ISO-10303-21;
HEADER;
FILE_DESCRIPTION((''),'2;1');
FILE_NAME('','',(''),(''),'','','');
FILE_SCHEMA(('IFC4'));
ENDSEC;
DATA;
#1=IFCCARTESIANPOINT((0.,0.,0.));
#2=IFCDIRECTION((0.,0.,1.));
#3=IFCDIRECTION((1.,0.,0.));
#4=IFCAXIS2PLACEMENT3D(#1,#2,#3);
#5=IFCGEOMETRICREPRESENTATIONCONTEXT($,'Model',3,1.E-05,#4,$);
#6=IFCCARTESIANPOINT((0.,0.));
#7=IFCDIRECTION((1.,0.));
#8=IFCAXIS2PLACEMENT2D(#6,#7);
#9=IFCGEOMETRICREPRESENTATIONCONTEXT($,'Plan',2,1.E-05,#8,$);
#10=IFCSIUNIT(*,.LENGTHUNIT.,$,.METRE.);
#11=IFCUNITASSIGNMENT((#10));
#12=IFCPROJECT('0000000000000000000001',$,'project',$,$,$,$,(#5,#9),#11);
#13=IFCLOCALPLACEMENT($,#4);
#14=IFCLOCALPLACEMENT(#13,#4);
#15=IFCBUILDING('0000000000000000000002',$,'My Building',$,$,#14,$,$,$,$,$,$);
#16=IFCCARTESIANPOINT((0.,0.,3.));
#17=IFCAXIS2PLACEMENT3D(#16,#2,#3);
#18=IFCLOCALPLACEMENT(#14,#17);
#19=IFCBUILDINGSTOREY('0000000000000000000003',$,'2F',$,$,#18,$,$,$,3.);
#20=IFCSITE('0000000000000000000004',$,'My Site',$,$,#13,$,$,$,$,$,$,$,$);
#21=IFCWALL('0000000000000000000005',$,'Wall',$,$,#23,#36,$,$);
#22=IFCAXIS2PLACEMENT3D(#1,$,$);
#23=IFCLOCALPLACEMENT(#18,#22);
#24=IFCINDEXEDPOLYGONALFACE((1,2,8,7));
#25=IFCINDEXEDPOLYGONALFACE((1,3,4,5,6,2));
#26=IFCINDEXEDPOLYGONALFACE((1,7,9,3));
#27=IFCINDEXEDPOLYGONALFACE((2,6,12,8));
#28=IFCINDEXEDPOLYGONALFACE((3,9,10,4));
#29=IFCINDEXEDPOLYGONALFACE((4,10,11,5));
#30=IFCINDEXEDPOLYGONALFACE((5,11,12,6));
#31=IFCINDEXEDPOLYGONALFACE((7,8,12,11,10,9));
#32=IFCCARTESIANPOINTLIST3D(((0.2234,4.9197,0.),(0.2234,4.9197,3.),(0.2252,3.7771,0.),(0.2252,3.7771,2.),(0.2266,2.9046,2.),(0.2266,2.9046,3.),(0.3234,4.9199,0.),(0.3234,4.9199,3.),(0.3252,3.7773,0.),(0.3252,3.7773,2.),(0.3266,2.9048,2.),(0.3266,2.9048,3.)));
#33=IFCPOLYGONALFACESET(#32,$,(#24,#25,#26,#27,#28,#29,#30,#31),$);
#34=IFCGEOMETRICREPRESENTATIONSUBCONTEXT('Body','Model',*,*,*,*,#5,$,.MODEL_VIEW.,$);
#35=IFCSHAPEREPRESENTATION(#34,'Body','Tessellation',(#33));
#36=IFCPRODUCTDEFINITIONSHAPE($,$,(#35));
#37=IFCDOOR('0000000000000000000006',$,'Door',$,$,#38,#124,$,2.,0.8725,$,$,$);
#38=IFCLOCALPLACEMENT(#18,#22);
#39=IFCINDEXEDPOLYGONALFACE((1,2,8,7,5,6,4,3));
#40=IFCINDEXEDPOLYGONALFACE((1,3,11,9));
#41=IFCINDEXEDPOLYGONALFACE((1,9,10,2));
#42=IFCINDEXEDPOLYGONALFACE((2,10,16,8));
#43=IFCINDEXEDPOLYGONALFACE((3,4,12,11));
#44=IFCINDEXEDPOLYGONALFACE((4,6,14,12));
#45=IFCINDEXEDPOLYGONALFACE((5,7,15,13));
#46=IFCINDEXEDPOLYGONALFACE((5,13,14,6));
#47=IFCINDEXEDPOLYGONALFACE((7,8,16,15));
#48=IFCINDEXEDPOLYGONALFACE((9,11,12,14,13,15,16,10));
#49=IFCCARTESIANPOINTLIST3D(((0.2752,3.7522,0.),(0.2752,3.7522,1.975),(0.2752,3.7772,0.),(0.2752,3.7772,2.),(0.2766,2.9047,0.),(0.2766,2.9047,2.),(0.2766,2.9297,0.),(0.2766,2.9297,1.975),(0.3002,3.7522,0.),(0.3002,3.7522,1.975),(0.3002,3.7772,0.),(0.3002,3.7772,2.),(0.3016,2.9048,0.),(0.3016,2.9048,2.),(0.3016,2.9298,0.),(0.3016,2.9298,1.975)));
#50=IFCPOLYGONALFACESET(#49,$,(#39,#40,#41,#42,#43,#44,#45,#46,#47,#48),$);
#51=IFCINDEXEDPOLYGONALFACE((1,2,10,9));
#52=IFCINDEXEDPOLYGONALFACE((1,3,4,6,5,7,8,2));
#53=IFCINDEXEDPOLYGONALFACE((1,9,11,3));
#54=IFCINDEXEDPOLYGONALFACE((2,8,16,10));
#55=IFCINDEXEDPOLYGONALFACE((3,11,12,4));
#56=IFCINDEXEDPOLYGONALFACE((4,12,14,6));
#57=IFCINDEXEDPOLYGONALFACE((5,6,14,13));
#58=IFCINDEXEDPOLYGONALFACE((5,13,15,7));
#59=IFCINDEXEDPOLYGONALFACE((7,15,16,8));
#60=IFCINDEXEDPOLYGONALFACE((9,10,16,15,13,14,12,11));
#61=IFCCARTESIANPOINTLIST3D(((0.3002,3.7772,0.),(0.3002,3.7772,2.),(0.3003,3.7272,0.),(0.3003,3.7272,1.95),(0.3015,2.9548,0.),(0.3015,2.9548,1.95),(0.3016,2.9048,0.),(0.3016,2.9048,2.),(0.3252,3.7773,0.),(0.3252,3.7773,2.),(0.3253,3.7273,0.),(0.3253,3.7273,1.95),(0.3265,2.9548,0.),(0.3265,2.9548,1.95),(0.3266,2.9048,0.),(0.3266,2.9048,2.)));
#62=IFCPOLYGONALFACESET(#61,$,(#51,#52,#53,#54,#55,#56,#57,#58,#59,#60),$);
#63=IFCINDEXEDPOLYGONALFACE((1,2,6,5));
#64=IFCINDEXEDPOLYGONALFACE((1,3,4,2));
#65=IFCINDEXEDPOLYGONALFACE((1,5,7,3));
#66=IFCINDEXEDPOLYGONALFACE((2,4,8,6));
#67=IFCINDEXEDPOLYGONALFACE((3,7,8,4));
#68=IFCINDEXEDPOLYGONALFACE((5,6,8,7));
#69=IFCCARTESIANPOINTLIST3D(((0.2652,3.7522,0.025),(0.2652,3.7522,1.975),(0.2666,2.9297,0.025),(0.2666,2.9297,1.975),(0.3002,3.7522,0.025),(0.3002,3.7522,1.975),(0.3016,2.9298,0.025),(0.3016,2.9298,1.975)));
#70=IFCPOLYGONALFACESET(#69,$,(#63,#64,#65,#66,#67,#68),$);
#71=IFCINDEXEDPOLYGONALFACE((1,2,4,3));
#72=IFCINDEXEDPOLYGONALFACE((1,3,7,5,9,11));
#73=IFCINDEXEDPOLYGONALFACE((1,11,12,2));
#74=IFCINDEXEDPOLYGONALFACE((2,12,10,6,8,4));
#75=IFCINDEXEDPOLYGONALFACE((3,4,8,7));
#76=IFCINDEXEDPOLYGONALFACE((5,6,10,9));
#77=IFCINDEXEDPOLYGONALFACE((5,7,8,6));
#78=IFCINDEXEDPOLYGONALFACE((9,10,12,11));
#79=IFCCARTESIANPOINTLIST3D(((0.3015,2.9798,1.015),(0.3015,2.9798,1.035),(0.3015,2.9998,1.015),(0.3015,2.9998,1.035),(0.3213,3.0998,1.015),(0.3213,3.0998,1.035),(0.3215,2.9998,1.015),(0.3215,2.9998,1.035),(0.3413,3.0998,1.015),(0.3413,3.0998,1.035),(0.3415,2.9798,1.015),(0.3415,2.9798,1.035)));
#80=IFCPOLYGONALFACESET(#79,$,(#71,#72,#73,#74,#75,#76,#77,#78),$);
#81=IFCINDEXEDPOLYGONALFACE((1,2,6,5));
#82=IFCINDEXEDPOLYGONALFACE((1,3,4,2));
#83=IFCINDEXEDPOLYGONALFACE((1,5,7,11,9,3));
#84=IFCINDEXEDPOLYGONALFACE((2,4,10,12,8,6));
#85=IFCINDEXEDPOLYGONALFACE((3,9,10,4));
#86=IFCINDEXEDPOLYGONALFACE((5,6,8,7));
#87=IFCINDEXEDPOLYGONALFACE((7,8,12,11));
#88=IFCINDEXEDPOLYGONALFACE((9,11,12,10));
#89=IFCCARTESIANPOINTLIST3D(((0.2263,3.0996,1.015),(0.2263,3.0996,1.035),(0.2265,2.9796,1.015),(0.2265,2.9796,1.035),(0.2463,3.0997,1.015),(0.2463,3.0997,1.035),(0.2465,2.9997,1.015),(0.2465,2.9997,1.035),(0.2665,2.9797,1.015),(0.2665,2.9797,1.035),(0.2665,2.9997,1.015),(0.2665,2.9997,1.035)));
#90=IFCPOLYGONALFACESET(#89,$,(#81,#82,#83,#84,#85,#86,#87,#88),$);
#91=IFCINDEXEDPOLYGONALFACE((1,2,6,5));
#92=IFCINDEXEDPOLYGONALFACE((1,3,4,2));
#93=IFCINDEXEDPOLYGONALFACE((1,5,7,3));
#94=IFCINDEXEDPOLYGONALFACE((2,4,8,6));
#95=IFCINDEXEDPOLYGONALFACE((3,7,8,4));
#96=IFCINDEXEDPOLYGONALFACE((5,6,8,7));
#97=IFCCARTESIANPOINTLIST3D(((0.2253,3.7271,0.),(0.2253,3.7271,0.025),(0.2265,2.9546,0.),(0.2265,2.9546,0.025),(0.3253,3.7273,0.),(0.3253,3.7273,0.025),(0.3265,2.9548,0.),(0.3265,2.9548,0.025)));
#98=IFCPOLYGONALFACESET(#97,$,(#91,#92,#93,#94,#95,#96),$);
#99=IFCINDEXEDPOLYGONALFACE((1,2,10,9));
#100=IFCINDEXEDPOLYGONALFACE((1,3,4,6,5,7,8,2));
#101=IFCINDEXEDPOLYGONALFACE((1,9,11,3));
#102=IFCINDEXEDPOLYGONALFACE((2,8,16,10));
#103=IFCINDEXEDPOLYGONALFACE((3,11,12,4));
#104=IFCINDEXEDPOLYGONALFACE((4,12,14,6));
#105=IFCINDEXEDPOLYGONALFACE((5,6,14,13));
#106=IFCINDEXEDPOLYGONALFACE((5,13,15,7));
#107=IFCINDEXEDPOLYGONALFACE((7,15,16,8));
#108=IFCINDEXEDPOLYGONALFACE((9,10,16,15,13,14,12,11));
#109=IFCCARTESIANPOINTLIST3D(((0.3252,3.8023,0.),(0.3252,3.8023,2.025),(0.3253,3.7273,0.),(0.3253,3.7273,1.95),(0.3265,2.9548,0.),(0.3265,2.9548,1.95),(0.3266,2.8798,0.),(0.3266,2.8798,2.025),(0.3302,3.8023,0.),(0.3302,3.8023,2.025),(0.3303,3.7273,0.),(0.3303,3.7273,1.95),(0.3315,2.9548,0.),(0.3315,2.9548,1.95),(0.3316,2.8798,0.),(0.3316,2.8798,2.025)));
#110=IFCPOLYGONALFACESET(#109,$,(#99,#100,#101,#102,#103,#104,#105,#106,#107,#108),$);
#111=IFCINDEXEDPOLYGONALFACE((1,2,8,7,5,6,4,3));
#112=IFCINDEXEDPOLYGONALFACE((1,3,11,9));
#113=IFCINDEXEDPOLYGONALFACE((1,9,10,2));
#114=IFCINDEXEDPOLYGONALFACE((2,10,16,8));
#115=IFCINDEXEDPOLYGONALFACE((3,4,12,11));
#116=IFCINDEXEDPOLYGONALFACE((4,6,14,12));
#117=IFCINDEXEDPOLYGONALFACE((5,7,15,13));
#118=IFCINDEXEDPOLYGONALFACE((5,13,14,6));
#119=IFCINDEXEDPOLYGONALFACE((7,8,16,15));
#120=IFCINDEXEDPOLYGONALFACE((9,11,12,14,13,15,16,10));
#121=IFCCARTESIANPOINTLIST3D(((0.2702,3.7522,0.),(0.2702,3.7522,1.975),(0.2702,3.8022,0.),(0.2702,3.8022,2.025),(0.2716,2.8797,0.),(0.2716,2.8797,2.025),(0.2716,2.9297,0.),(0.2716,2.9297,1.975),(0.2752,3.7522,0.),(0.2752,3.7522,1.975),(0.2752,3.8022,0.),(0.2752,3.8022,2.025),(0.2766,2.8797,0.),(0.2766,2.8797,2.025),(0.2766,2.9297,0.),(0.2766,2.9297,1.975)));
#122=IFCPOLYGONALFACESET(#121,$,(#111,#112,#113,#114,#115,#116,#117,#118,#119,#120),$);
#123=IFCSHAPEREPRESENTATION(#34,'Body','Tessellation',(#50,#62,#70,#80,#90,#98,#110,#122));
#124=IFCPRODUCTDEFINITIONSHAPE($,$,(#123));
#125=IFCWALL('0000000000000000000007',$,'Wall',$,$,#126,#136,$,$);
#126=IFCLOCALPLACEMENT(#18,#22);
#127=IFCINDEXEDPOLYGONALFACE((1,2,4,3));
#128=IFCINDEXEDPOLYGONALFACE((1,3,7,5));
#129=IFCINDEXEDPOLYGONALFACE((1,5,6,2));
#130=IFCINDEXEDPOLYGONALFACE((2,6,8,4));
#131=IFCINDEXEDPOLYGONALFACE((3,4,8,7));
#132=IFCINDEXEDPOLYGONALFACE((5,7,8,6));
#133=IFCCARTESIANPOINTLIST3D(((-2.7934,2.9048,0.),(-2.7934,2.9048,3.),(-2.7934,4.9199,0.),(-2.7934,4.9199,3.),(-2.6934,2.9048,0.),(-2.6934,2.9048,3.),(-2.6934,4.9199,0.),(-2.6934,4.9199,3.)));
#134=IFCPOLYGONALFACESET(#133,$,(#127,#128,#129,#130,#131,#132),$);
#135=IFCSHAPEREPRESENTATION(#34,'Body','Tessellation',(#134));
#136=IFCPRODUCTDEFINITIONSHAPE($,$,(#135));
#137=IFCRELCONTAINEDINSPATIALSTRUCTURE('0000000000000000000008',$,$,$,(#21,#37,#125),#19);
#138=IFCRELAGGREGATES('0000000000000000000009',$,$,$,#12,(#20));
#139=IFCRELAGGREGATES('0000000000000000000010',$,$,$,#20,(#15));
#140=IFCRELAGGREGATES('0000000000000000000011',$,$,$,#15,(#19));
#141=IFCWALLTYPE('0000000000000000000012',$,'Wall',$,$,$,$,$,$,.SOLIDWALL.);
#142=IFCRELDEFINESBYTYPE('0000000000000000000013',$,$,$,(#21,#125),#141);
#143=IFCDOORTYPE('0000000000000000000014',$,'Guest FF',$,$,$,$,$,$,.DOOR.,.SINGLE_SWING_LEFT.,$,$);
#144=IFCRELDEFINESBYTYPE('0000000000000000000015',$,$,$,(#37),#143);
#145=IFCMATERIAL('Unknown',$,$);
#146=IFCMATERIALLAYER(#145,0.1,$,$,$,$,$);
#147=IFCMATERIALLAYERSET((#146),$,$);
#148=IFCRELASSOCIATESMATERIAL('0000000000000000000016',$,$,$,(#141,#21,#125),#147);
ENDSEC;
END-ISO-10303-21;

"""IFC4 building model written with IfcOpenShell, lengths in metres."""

from ifc_helpers import new_model, entity, si_unit, frame, origin_with_axes, origin_2d_with_axis, place, context, subcontext, project, spatial, line, indexed_curve, outline, extrude, shape, source, transform, mapped, material, layer, layer_set, layer_usage, type_object, type_shapes, element, fill, save


model = new_model("IFC4")

# Units and contexts
model_context = context("Model", 3, precision=1e-05, world=origin_with_axes())
plan_context = context("Plan", 2, precision=1e-05, world=origin_2d_with_axis())
body_context_1 = subcontext(model_context, "Body", "Model", "MODEL_VIEW")
body_context_2 = subcontext(plan_context, "Body", "Plan", "PLAN_VIEW")
ifc_project = project(units=[si_unit("LENGTHUNIT", "METRE")], contexts=[model_context, plan_context])

# Site, building, storey
site_placement = place(None, origin_with_axes())
site = spatial("IfcSite", under=ifc_project, at=site_placement, Name="My Site")
building_placement = place(site_placement, origin_with_axes())
building = spatial("IfcBuilding", under=site, at=building_placement, Name="My Building")
storey_placement = place(building_placement, frame((0.0, 0.0, 3.0), z_axis=(0.0, 0.0, 1.0), x_axis=(1.0, 0.0, 0.0)))
storey = spatial("IfcBuildingStorey", under=building, at=storey_placement, Name="2F", Elevation=3.0)

# Shared definitions
ifc_material = material(Name="Unknown")

# Shared definitions
ifc_layer_1 = layer(ifc_material, 0.1)
ifc_layer_set_1 = layer_set([ifc_layer_1])
wall_type = type_object("IfcWallType", Name="Wall", PredefinedType="SOLIDWALL", material=ifc_layer_set_1)

# Shared definitions
shared_shape_1 = source(origin_with_axes(), body_context_1, "Body", "SweptSolid", [
    extrude(outline(indexed_curve([(0.0, 0.0), (0.8725, 0.0), (0.8725, 2.0), (0.0, 2.0)], segments=[line(1, 2, 3, 4, 1)])), frame((0.0, -0.6, 0.0), z_axis=(0.0, -1.0, 0.0), x_axis=(1.0, 0.0, 0.0)), (0.0, 0.0, -1.0), 1.2),
])
door_type_1 = type_object("IfcDoorType", Name="Guest FF", OperationType="SINGLE_SWING_LEFT", PredefinedType="DOOR")
shared_shape_2 = source(origin_with_axes(), body_context_1, "Body", "SweptSolid", [
    extrude(outline(indexed_curve([(0.0, 0.0), (0.0, 2.0), (0.8725, 2.0), (0.8725, 0.0), (0.8475, 0.0), (0.8475, 1.975), (0.025, 1.975), (0.025, 0.0)], segments=[line(1, 2, 3, 4, 5, 6, 7, 8, 1)])), frame((0.0, 0.025, 0.0), z_axis=(0.0, -1.0, 0.0), x_axis=(1.0, 0.0, 0.0)), (0.0, 0.0, -1.0), 0.025),
    extrude(outline(indexed_curve([(0.0, 0.0), (0.0, 2.0), (0.8725, 2.0), (0.8725, 0.0), (0.8225, 0.0), (0.8225, 1.95), (0.05, 1.95), (0.05, 0.0)], segments=[line(1, 2, 3, 4, 5, 6, 7, 8, 1)])), frame((0.0, 0.0, 0.0), z_axis=(0.0, -1.0, 0.0), x_axis=(1.0, 0.0, 0.0)), (0.0, 0.0, -1.0), 0.025),
    extrude(outline(indexed_curve([(0.0, 0.0), (0.8225, 0.0), (0.8225, 0.035), (0.0, 0.035)], segments=[line(1, 2, 3, 4, 1)])), frame((0.025, 0.025, 0.025), z_axis=(0.0, 0.0, 1.0), x_axis=(1.0, 0.0, 0.0)), (0.0, 0.0, 1.0), 1.95),
    extrude(outline(indexed_curve([(0.0, 0.0), (0.0, -0.04), (0.12, -0.04), (0.12, -0.02), (0.02, -0.02), (0.02, 0.0)], segments=[line(1, 2, 3, 4, 5, 6, 1)])), frame((0.075, 0.025, 1.015), z_axis=(0.0, 0.0, 1.0), x_axis=(1.0, 0.0, 0.0)), (0.0, 0.0, 1.0), 0.02),
    extrude(outline(indexed_curve([(0.0, 0.0), (0.0, 0.04), (0.12, 0.04), (0.12, 0.02), (0.02, 0.02), (0.02, 0.0)], segments=[line(1, 2, 3, 4, 5, 6, 1)])), frame((0.075, 0.06, 1.015), z_axis=(0.0, 0.0, 1.0), x_axis=(1.0, 0.0, 0.0)), (0.0, 0.0, 1.0), 0.02),
    extrude(outline(indexed_curve([(0.0, 0.0), (0.7725, 0.0), (0.7725, 0.1), (0.0, 0.1)], segments=[line(1, 2, 3, 4, 1)])), frame((0.05, 0.0, 0.0), z_axis=(0.0, 0.0, 1.0), x_axis=(1.0, 0.0, 0.0)), (0.0, 0.0, 1.0), 0.025),
    extrude(outline(indexed_curve([(0.0, 0.0), (0.0, 2.025), (0.9225, 2.025), (0.9225, 0.0), (0.8475, 0.0), (0.8475, 1.95), (0.075, 1.95), (0.075, 0.0)], segments=[line(1, 2, 3, 4, 5, 6, 7, 8, 1)])), frame((-0.025, -0.005, 0.0), z_axis=(0.0, -1.0, 0.0), x_axis=(1.0, 0.0, 0.0)), (0.0, 0.0, -1.0), 0.005),
    extrude(outline(indexed_curve([(0.0, 0.0), (0.0, 2.025), (0.9225, 2.025), (0.9225, 0.0), (0.8725, 0.0), (0.8725, 1.975), (0.05, 1.975), (0.05, 0.0)], segments=[line(1, 2, 3, 4, 5, 6, 7, 8, 1)])), frame((-0.025, 0.05, 0.0), z_axis=(0.0, -1.0, 0.0), x_axis=(1.0, 0.0, 0.0)), (0.0, 0.0, -1.0), 0.005),
])
shared_shape_3 = source(origin_with_axes(), body_context_2, "Body", "Curve2D", [
    entity("IfcIndexedPolyCurve", entity("IfcCartesianPointList2D", [[0.0, 0.0], [0.0, 0.05], [0.025, 0.05], [0.025, 0.025], [0.05, 0.025], [0.05, 0.0]]), [entity("IfcLineIndex", [1, 2, 3, 4, 5, 6, 1])]),
    entity("IfcIndexedPolyCurve", entity("IfcCartesianPointList2D", [[0.8725, 0.0], [0.8725, 0.05], [0.8475, 0.05], [0.8475, 0.025], [0.8225, 0.025], [0.8225, 0.0]]), [entity("IfcLineIndex", [1, 2, 3, 4, 5, 6, 1])]),
    entity("IfcTrimmedCurve", entity("IfcEllipse", entity("IfcAxis2Placement2D", entity("IfcCartesianPoint", [0.8125, 0.05]), entity("IfcDirection", [1.0, 0.0])), 0.7875, 0.8225), [entity("IfcCartesianPoint", [0.8125, 0.8725])], [entity("IfcCartesianPoint", [0.025, 0.05])], True, "CARTESIAN"),
    entity("IfcIndexedPolyCurve", entity("IfcCartesianPointList2D", [[0.8475, 0.05], [0.8125, 0.05], [0.8125, 0.8725], [0.8475, 0.8725]]), [entity("IfcLineIndex", [1, 2, 3, 4, 1])]),
])
type_shapes(door_type_1, [shared_shape_2, shared_shape_3])

# Wall, opening, door
ifc_layer_usage_1 = layer_usage(ifc_layer_set_1, "AXIS2", "POSITIVE", 0.0)
wall_1_placement = place(storey_placement, frame((0.3266, 2.9048, 0.0), z_axis=(0.0, 0.0, 1.0), x_axis=(-0.001613, 0.999999, 0.0)))
wall_1 = element("IfcWall", 1, at=wall_1_placement, inside=storey, type_object=wall_type, material=ifc_layer_usage_1, Name="Wall", context=body_context_1, shape_type="SweptSolid", body=[
    extrude(outline(indexed_curve([(0.0, 0.0), (0.0, 0.1), (2.0151, 0.1), (2.0151, 0.0)], segments=[line(1, 2, 3, 4, 1)])), origin_with_axes(), (0.0, 0.0, 1.0), 3.0),
])
opening_1_placement = place(wall_1_placement, frame((0.0, 0.0, 0.0), z_axis=(0.0, 0.0, 1.0), x_axis=(1.0, 0.0, 0.0)))
opening_1 = element("IfcOpeningElement", 2, at=opening_1_placement, cuts=wall_1, PredefinedType="OPENING", context=body_context_1, shape_type="MappedRepresentation", body=[
    mapped(shared_shape_1, transform((0.0, 0.0, 0.0), x_axis=(1.0, 0.0, 0.0), y_axis=(0.0, 1.0, 0.0), z_axis=(0.0, 0.0, 1.0), scale=1.0)),
])
door_1_placement = place(opening_1_placement, frame((0.0, 0.0, 0.0), z_axis=(0.0, 0.0, 1.0), x_axis=(1.0, 0.0, 0.0)))
door_1 = element("IfcDoor", 3, at=door_1_placement, inside=storey, type_object=door_type_1, Name="Door", OverallHeight=2.0, OverallWidth=0.8725, shapes=[
    shape(body_context_1, "Body", "MappedRepresentation", [mapped(shared_shape_2, transform((0.0, 0.0, 0.0), x_axis=(1.0, 0.0, 0.0), y_axis=(0.0, 1.0, 0.0), z_axis=(0.0, 0.0, 1.0), scale=1.0))]),
    shape(body_context_2, "Body", "MappedRepresentation", [mapped(shared_shape_3, transform((0.0, 0.0, 0.0), x_axis=(1.0, 0.0, 0.0), y_axis=(0.0, 1.0, 0.0), z_axis=(0.0, 0.0, 1.0), scale=1.0))]),
])
fill(opening_1, door_1)

# Wall
ifc_layer_usage_2 = layer_usage(ifc_layer_set_1, "AXIS2", "POSITIVE", 0.0)
wall_2_placement = place(storey_placement, frame((-2.6934, 2.9048, 0.0), z_axis=(0.0, 0.0, 1.0), x_axis=(0.0, 1.0, 0.0)))
element("IfcWall", 4, at=wall_2_placement, inside=storey, type_object=wall_type, material=ifc_layer_usage_2, Name="Wall", context=body_context_1, shape_type="SweptSolid", body=[
    extrude(outline(indexed_curve([(0.0, 0.0), (0.0, 0.1), (2.0151, 0.1), (2.0151, 0.0)], segments=[line(1, 2, 3, 4, 1)])), origin_with_axes(), (0.0, 0.0, 1.0), 3.0),
])

save(model, "model.ifc")
